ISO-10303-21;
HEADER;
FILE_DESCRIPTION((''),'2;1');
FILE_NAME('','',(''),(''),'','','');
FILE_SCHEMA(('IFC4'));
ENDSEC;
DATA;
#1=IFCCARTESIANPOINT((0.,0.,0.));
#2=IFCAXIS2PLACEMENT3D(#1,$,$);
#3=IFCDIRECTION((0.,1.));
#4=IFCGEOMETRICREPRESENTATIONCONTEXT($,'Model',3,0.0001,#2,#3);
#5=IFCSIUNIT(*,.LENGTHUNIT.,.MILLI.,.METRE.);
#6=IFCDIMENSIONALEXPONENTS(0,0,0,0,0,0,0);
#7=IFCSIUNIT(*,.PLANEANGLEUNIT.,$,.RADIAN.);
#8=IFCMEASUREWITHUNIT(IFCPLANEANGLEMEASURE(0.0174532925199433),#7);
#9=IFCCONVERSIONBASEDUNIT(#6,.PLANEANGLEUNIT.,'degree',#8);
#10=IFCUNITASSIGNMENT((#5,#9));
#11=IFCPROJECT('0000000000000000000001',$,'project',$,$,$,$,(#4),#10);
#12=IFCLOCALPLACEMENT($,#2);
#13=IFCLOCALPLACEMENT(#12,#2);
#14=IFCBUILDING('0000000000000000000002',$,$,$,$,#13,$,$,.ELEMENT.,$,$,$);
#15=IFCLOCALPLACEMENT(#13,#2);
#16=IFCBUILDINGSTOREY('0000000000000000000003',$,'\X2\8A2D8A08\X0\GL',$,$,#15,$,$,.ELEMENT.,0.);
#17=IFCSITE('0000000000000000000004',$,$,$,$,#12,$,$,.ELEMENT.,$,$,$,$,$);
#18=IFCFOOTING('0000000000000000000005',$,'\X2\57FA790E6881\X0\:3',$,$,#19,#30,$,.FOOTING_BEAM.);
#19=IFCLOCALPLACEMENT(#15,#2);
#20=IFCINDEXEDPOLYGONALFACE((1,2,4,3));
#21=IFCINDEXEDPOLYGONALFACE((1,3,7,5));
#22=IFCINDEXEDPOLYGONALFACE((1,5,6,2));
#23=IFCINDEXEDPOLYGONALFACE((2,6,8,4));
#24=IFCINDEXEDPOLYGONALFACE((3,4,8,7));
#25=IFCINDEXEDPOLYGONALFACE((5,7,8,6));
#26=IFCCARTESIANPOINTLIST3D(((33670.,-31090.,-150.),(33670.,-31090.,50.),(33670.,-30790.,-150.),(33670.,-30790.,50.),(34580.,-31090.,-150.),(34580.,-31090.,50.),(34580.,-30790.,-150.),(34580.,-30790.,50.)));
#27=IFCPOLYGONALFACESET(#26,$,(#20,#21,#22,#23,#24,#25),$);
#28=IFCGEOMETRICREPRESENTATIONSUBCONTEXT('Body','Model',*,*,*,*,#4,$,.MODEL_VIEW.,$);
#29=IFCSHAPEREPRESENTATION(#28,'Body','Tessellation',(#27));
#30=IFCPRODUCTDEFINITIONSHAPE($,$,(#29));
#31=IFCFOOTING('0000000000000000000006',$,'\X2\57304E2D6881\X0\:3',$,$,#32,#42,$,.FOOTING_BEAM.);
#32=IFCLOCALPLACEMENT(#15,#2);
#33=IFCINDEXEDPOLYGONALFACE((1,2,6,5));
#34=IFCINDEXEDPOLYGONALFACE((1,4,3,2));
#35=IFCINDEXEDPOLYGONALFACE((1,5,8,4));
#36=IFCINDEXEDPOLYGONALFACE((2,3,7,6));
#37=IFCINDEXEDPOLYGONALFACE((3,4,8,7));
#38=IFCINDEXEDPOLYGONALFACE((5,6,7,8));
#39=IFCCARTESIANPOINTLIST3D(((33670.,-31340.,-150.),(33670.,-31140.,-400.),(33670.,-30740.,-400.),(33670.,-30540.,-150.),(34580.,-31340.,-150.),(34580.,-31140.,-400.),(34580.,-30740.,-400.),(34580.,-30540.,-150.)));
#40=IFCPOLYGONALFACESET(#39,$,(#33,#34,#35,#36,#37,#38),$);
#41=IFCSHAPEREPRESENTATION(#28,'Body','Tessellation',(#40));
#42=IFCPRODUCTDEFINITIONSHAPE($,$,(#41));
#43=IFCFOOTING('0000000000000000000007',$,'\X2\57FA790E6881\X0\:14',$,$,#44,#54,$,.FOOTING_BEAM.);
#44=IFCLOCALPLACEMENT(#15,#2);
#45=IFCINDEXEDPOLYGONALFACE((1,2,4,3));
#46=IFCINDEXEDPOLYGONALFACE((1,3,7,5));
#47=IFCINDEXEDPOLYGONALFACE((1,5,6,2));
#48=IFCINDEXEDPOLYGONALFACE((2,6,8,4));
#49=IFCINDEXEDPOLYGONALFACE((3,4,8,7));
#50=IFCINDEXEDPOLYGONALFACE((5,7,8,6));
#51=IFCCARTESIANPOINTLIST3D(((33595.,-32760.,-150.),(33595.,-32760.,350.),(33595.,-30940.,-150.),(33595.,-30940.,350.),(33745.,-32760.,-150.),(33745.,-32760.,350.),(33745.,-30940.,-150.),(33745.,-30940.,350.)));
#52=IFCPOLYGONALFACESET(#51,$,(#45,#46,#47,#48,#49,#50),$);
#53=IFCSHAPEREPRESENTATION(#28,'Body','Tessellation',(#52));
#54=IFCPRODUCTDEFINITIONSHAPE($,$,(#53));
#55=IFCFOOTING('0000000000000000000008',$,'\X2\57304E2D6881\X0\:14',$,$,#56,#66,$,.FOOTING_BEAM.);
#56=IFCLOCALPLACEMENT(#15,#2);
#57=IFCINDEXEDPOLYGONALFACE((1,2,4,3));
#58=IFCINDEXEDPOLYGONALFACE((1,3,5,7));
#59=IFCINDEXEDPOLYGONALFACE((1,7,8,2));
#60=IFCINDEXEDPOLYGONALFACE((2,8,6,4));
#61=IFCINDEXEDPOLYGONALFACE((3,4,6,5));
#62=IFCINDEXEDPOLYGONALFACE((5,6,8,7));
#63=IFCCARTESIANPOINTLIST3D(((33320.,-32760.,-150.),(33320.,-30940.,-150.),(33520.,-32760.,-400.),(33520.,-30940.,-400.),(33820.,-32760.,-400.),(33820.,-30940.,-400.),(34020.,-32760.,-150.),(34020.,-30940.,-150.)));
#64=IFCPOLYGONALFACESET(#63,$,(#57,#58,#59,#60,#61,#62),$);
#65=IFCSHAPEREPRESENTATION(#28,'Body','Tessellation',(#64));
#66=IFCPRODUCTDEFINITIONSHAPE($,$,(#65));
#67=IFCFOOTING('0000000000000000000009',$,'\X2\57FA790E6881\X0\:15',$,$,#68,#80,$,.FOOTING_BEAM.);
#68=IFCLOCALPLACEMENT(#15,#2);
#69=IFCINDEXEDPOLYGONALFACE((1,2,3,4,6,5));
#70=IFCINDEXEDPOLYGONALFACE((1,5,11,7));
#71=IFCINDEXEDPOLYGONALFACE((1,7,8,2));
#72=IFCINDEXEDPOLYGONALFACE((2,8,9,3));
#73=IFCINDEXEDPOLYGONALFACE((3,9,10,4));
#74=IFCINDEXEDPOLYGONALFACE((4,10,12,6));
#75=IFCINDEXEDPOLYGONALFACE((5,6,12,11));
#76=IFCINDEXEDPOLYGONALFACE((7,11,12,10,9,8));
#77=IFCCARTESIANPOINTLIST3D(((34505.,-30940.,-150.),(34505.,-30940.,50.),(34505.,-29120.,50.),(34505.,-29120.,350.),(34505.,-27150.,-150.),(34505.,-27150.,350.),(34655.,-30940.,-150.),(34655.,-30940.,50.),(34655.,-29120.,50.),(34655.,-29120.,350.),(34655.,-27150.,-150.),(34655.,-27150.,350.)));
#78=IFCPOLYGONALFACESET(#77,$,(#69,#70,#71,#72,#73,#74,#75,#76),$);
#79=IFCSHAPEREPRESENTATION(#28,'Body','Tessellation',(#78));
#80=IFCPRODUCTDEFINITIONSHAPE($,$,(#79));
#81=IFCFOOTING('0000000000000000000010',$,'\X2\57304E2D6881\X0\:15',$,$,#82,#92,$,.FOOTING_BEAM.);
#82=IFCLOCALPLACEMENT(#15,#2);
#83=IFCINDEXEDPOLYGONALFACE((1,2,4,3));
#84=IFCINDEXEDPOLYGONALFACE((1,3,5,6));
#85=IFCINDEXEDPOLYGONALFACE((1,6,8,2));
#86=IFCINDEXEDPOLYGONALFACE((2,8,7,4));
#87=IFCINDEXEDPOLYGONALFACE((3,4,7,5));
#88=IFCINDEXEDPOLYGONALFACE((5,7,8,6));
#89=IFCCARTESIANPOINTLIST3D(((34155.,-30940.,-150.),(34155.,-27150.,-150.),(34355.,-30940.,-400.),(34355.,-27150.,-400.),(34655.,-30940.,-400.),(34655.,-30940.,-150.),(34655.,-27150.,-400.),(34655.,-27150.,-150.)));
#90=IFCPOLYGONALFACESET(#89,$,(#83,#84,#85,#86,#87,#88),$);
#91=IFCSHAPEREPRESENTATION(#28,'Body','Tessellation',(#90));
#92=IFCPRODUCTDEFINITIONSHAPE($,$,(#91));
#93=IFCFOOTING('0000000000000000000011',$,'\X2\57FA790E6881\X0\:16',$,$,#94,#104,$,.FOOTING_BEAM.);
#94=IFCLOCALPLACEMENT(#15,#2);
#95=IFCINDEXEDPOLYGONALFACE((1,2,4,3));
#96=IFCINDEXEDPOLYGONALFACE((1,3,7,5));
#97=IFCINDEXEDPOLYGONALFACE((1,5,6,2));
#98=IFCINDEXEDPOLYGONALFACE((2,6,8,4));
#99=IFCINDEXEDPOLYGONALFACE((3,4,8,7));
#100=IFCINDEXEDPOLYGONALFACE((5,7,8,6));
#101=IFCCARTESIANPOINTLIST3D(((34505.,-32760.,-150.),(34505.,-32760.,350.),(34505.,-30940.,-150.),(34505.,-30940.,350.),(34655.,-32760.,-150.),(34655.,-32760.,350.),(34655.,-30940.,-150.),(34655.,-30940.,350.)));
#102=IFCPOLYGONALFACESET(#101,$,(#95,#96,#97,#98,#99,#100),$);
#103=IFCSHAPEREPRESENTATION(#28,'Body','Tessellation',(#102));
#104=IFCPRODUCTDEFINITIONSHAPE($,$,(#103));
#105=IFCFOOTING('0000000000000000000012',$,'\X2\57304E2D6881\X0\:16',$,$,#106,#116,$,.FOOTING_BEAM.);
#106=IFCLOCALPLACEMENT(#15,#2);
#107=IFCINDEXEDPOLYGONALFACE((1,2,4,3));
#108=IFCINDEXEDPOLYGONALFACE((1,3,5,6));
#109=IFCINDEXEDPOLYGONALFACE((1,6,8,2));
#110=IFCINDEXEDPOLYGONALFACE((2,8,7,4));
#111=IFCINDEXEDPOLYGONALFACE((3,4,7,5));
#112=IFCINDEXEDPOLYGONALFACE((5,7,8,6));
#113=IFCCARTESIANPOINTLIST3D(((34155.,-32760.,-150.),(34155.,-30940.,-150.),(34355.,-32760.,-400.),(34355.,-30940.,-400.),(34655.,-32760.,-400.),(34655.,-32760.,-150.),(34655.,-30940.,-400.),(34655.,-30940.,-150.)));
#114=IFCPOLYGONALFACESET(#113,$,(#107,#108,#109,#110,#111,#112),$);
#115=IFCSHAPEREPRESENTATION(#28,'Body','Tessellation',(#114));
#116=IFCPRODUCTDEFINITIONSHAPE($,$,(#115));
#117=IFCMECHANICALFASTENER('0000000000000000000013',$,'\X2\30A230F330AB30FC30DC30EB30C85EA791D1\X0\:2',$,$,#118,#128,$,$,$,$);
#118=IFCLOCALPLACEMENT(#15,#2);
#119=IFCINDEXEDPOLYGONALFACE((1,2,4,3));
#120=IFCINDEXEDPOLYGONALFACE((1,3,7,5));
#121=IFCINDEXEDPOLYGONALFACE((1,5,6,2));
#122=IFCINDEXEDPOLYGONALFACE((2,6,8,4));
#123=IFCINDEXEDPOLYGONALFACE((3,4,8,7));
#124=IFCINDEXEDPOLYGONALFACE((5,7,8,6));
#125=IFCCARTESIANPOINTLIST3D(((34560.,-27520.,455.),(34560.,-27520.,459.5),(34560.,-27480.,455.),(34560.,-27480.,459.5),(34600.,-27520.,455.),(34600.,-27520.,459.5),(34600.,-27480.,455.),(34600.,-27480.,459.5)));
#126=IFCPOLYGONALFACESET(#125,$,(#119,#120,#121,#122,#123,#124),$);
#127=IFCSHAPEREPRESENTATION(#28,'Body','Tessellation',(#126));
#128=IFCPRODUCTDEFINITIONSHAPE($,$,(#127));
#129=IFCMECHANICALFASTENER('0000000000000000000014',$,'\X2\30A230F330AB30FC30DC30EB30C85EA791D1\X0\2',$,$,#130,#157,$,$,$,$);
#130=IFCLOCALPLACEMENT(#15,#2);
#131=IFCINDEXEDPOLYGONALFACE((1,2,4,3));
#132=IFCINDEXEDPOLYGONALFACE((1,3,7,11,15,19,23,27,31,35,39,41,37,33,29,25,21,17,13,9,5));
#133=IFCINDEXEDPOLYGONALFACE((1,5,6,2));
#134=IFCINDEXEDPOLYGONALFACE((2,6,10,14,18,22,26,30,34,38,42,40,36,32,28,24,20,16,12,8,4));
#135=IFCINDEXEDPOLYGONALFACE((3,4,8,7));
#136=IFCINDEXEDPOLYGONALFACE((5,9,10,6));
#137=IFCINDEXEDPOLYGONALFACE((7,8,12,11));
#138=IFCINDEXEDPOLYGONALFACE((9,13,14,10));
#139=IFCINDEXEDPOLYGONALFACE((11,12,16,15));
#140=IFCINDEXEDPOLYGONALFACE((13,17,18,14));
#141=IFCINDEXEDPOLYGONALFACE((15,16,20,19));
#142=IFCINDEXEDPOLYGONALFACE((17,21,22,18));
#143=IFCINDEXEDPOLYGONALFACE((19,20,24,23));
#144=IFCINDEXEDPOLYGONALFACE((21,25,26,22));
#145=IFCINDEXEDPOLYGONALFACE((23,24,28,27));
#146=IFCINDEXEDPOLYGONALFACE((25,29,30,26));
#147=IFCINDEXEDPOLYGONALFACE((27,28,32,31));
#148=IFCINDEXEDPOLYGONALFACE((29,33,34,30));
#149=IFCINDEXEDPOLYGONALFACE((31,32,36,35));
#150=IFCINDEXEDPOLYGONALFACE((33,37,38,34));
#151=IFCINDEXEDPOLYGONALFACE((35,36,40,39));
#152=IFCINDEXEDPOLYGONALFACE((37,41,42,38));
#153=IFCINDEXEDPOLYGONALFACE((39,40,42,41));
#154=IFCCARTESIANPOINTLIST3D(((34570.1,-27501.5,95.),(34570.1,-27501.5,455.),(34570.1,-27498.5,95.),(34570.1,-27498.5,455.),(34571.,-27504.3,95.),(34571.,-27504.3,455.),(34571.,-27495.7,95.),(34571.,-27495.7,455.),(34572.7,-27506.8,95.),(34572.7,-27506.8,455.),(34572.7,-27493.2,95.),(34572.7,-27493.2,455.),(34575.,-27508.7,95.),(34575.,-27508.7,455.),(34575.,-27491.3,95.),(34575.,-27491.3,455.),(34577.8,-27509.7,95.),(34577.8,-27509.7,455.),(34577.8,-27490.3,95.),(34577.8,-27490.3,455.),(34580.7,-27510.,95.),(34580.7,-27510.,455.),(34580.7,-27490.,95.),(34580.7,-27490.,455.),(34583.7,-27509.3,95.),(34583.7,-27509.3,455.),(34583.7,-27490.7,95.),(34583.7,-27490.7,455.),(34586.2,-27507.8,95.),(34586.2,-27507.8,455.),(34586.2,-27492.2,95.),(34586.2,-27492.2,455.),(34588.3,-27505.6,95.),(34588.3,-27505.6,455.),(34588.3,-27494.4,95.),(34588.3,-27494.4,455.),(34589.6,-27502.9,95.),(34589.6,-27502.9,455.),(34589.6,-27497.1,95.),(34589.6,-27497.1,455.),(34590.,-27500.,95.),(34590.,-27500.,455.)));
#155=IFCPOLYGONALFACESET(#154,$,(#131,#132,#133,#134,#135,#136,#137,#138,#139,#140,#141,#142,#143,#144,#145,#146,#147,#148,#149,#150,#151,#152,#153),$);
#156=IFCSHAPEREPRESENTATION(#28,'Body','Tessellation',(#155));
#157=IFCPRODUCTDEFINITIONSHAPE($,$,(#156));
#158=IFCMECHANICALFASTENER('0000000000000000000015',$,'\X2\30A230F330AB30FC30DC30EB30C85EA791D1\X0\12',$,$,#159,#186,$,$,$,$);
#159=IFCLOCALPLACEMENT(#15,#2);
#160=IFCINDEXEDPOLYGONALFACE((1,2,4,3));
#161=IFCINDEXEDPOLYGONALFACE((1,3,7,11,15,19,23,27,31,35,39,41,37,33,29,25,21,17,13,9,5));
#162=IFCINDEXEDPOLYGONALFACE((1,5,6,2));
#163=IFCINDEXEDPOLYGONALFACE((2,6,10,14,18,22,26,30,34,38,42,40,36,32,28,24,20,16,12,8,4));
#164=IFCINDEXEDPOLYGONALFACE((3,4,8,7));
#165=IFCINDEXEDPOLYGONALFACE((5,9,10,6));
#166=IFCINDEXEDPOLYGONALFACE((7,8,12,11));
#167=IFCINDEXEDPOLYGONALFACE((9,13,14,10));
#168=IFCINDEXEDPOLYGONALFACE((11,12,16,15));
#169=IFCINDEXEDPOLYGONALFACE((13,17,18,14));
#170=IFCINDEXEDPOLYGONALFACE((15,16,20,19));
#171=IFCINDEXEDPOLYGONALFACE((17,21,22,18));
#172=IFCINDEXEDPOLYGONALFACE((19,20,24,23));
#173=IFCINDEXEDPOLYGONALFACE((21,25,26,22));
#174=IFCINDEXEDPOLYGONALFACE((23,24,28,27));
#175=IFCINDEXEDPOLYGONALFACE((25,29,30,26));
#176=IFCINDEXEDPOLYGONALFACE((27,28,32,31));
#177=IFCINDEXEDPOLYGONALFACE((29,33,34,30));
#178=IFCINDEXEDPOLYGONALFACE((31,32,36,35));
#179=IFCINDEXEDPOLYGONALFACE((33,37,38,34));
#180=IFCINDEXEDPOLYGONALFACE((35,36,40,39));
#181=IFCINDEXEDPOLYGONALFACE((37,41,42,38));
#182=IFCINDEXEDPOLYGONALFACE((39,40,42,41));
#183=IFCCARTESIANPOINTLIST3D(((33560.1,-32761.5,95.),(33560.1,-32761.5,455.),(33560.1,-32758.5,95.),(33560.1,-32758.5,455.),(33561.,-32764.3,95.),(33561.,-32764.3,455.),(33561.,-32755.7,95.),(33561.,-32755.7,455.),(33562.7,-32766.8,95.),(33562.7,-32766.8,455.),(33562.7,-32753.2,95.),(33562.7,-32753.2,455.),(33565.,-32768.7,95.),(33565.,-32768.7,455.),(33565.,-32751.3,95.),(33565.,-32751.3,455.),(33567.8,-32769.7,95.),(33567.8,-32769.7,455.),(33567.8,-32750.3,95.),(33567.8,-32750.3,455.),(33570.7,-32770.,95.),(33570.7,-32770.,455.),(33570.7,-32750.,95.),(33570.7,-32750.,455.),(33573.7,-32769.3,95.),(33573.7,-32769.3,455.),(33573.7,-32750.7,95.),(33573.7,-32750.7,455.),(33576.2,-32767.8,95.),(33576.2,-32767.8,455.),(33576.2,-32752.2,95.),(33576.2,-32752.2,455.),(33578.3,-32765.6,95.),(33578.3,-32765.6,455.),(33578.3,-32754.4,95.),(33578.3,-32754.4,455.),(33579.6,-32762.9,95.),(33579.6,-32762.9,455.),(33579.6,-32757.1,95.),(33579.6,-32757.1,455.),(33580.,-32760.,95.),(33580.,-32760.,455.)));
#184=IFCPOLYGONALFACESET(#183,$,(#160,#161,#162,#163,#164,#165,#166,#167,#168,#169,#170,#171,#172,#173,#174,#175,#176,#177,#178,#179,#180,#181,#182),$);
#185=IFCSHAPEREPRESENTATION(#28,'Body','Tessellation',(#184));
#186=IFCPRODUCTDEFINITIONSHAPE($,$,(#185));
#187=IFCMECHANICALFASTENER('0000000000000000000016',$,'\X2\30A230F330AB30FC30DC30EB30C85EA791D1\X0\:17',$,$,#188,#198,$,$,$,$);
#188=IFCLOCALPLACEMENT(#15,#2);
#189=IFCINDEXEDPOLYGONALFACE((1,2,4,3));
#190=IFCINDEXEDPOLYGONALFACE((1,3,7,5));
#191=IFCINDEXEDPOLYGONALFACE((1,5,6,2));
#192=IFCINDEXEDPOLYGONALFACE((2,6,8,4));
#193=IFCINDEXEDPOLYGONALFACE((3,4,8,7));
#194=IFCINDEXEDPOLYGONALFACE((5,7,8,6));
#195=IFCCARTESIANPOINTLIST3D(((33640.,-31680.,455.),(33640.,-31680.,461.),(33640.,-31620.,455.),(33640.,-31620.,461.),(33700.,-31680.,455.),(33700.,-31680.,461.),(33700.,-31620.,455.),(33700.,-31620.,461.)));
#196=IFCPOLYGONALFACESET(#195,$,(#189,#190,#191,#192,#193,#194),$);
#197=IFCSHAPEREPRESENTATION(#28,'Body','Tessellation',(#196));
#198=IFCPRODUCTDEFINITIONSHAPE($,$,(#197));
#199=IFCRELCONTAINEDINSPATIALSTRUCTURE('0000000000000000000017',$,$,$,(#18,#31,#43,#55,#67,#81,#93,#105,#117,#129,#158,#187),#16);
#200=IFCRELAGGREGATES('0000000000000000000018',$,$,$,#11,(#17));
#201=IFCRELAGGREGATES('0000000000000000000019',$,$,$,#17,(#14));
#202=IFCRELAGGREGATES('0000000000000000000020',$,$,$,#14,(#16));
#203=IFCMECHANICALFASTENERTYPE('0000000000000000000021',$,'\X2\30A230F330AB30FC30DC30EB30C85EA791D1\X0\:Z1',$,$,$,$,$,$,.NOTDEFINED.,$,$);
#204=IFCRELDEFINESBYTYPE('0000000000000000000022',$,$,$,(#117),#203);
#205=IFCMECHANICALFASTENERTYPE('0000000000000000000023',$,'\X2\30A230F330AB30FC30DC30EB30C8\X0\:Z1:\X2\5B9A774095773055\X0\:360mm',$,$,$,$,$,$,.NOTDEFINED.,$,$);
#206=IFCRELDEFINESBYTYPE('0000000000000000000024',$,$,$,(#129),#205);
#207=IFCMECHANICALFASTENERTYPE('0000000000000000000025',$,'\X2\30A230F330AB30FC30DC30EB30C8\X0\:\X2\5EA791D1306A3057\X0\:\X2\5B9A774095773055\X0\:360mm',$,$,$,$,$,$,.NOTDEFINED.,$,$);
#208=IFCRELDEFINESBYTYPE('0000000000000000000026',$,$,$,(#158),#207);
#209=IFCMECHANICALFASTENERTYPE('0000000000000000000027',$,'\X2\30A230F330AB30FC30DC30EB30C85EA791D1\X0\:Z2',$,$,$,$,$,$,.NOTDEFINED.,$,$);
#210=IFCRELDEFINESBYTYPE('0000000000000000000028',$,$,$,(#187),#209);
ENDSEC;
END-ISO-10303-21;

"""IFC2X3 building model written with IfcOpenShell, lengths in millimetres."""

from ifc_helpers import new_model, entity, si_unit, converted_unit, direction, frame, origin, origin_with_axes, origin_2d, place, context, subcontext, project, spatial, polyline, rectangle, circle, outline, extrude, boolean, type_object, element, save


model = new_model("IFC2X3")

# Units and contexts
model_context = context("Model", 3, precision=0.0001, world=origin(), true_north=direction((0.0, 1.0)))
body_context = subcontext(model_context, "Body", "Model", "MODEL_VIEW")
ifc_project = project(units=[si_unit("LENGTHUNIT", "METRE", prefix="MILLI"), converted_unit("PLANEANGLEUNIT", "degree", entity("IfcPlaneAngleMeasure", 0.0174532925199433), si_unit("PLANEANGLEUNIT", "RADIAN"), dimensions=[0, 0, 0, 0, 0, 0, 0])], contexts=[model_context])

# Site, building, storey
site_placement = place(None, origin())
site = spatial("IfcSite", under=ifc_project, at=site_placement, CompositionType="ELEMENT")
building_placement = place(site_placement, origin())
building = spatial("IfcBuilding", under=site, at=building_placement, CompositionType="ELEMENT")
storey_placement = place(building_placement, origin())
storey = spatial("IfcBuildingStorey", under=building, at=storey_placement, Name="設計GL", CompositionType="ELEMENT", Elevation=0.0)

# Footings
footing_1_placement = place(storey_placement, frame((33670.0, -30940.0, -50.0), z_axis=(1.0, 0.0, 0.0), x_axis=(0.0, 1.0, 0.0)))
element("IfcFooting", 1, at=footing_1_placement, inside=storey, Name="基礎梁:3", PredefinedType="FOOTING_BEAM", context=body_context, shape_type="SolidModel", body=[
    extrude(rectangle(XDim=300.0, YDim=200.0, at=origin_2d()), origin_with_axes(), (0.0, 0.0, 1.0), 910.0),
])
footing_2_placement = place(storey_placement, frame((33670.0, -30940.0, -400.0), z_axis=(1.0, 0.0, 0.0), x_axis=(0.0, 1.0, 0.0)))
element("IfcFooting", 2, at=footing_2_placement, inside=storey, Name="地中梁:3", PredefinedType="FOOTING_BEAM", context=body_context, shape_type="SweptSolid", body=[
    extrude(outline(polyline([(-200.0, 0.0, 0.0), (200.0, 0.0, 0.0), (400.0, 250.0, 0.0), (-400.0, 250.0, 0.0), (-200.0, 0.0, 0.0)])), origin_with_axes(), (0.0, 0.0, 1.0), 910.0),
])
footing_3_placement = place(storey_placement, frame((33670.0, -30940.0, 100.0), z_axis=(0.0, -1.0, 0.0), x_axis=(1.0, 0.0, 0.0)))
element("IfcFooting", 3, at=footing_3_placement, inside=storey, Name="基礎梁:14", PredefinedType="FOOTING_BEAM", context=body_context, shape_type="SolidModel", body=[
    extrude(rectangle(XDim=150.0, YDim=500.0, at=origin_2d()), origin_with_axes(), (0.0, 0.0, 1.0), 1820.0),
])
footing_4_placement = place(storey_placement, frame((33670.0, -30940.0, -400.0), z_axis=(0.0, -1.0, 0.0), x_axis=(1.0, 0.0, 0.0)))
element("IfcFooting", 4, at=footing_4_placement, inside=storey, Name="地中梁:14", PredefinedType="FOOTING_BEAM", context=body_context, shape_type="SweptSolid", body=[
    extrude(outline(polyline([(-150.0, 0.0, 0.0), (150.0, 0.0, 0.0), (350.0, 250.0, 0.0), (-350.0, 250.0, 0.0), (-150.0, 0.0, 0.0)])), origin_with_axes(), (0.0, 0.0, 1.0), 1820.0),
])
footing_5_placement = place(storey_placement, frame((34580.0, -27150.0, 100.0), z_axis=(0.0, -1.0, 0.0), x_axis=(1.0, 0.0, 0.0)))
element("IfcFooting", 5, at=footing_5_placement, inside=storey, Name="基礎梁:15", PredefinedType="FOOTING_BEAM", context=body_context, shape_type="CSG", body=[
    boolean("DIFFERENCE", extrude(rectangle(XDim=150.0, YDim=500.0, at=origin_2d()), origin_with_axes(), (0.0, 0.0, 1.0), 3790.0), extrude(rectangle(XDim=154.0, YDim=300.0, at=origin_2d()), frame((0.0, 100.0, 1970.0), z_axis=(0.0, 0.0, 1.0), x_axis=(1.0, 0.0, 0.0)), (0.0, 0.0, 1.0), 1820.0)),
])
footing_6_placement = place(storey_placement, frame((34655.0, -27150.0, -400.0), z_axis=(0.0, -1.0, 0.0), x_axis=(1.0, 0.0, 0.0)))
element("IfcFooting", 6, at=footing_6_placement, inside=storey, Name="地中梁:15", PredefinedType="FOOTING_BEAM", context=body_context, shape_type="SweptSolid", body=[
    extrude(outline(polyline([(0.0, 0.0, 0.0), (-300.0, 0.0, 0.0), (-500.0, 250.0, 0.0), (0.0, 250.0, 0.0), (0.0, 0.0, 0.0)])), origin_with_axes(), (0.0, 0.0, 1.0), 3790.0),
])
footing_7_placement = place(storey_placement, frame((34580.0, -30940.0, 100.0), z_axis=(0.0, -1.0, 0.0), x_axis=(1.0, 0.0, 0.0)))
element("IfcFooting", 7, at=footing_7_placement, inside=storey, Name="基礎梁:16", PredefinedType="FOOTING_BEAM", context=body_context, shape_type="SolidModel", body=[
    extrude(rectangle(XDim=150.0, YDim=500.0, at=origin_2d()), origin_with_axes(), (0.0, 0.0, 1.0), 1820.0),
])
footing_8_placement = place(storey_placement, frame((34655.0, -30940.0, -400.0), z_axis=(0.0, -1.0, 0.0), x_axis=(1.0, 0.0, 0.0)))
element("IfcFooting", 8, at=footing_8_placement, inside=storey, Name="地中梁:16", PredefinedType="FOOTING_BEAM", context=body_context, shape_type="SweptSolid", body=[
    extrude(outline(polyline([(0.0, 0.0, 0.0), (-300.0, 0.0, 0.0), (-500.0, 250.0, 0.0), (0.0, 250.0, 0.0), (0.0, 0.0, 0.0)])), origin_with_axes(), (0.0, 0.0, 1.0), 1820.0),
])

# Mechanical fasteners
mechanical_fastener_type_1 = type_object("IfcMechanicalFastenerType", Name="アンカーボルト座金:Z1")
mechanical_fastener_1_placement = place(storey_placement, frame((34580.0, -27500.0, 455.0)))
element("IfcMechanicalFastener", 9, at=mechanical_fastener_1_placement, inside=storey, type_object=mechanical_fastener_type_1, Name="アンカーボルト座金:2", context=body_context, shape_type="SweptSolid", body=[
    extrude(rectangle(XDim=40.0, YDim=40.0, at=origin_2d()), origin_with_axes(), (0.0, 0.0, 1.0), 4.5),
])
mechanical_fastener_type_2 = type_object("IfcMechanicalFastenerType", Name="アンカーボルト:Z1:定着長さ:360mm")
mechanical_fastener_2_placement = place(storey_placement, frame((34580.0, -27500.0, 95.0)))
element("IfcMechanicalFastener", 10, at=mechanical_fastener_2_placement, inside=storey, type_object=mechanical_fastener_type_2, Name="アンカーボルト座金2", context=body_context, shape_type="SweptSolid", body=[
    extrude(circle(Radius=10.0, at=origin_2d()), origin_with_axes(), (0.0, 0.0, 1.0), 360.0),
])
mechanical_fastener_type_3 = type_object("IfcMechanicalFastenerType", Name="アンカーボルト:座金なし:定着長さ:360mm")
mechanical_fastener_3_placement = place(storey_placement, frame((33570.0, -32760.0, 95.0)))
element("IfcMechanicalFastener", 11, at=mechanical_fastener_3_placement, inside=storey, type_object=mechanical_fastener_type_3, Name="アンカーボルト座金12", context=body_context, shape_type="SweptSolid", body=[
    extrude(circle(Radius=10.0, at=origin_2d()), origin_with_axes(), (0.0, 0.0, 1.0), 360.0),
])
mechanical_fastener_type_4 = type_object("IfcMechanicalFastenerType", Name="アンカーボルト座金:Z2")
mechanical_fastener_4_placement = place(storey_placement, frame((33670.0, -31650.0, 455.0)))
element("IfcMechanicalFastener", 12, at=mechanical_fastener_4_placement, inside=storey, type_object=mechanical_fastener_type_4, Name="アンカーボルト座金:17", context=body_context, shape_type="SweptSolid", body=[
    extrude(rectangle(XDim=60.0, YDim=60.0, at=origin_2d()), origin_with_axes(), (0.0, 0.0, 1.0), 6.0),
])

save(model, "model.ifc")
